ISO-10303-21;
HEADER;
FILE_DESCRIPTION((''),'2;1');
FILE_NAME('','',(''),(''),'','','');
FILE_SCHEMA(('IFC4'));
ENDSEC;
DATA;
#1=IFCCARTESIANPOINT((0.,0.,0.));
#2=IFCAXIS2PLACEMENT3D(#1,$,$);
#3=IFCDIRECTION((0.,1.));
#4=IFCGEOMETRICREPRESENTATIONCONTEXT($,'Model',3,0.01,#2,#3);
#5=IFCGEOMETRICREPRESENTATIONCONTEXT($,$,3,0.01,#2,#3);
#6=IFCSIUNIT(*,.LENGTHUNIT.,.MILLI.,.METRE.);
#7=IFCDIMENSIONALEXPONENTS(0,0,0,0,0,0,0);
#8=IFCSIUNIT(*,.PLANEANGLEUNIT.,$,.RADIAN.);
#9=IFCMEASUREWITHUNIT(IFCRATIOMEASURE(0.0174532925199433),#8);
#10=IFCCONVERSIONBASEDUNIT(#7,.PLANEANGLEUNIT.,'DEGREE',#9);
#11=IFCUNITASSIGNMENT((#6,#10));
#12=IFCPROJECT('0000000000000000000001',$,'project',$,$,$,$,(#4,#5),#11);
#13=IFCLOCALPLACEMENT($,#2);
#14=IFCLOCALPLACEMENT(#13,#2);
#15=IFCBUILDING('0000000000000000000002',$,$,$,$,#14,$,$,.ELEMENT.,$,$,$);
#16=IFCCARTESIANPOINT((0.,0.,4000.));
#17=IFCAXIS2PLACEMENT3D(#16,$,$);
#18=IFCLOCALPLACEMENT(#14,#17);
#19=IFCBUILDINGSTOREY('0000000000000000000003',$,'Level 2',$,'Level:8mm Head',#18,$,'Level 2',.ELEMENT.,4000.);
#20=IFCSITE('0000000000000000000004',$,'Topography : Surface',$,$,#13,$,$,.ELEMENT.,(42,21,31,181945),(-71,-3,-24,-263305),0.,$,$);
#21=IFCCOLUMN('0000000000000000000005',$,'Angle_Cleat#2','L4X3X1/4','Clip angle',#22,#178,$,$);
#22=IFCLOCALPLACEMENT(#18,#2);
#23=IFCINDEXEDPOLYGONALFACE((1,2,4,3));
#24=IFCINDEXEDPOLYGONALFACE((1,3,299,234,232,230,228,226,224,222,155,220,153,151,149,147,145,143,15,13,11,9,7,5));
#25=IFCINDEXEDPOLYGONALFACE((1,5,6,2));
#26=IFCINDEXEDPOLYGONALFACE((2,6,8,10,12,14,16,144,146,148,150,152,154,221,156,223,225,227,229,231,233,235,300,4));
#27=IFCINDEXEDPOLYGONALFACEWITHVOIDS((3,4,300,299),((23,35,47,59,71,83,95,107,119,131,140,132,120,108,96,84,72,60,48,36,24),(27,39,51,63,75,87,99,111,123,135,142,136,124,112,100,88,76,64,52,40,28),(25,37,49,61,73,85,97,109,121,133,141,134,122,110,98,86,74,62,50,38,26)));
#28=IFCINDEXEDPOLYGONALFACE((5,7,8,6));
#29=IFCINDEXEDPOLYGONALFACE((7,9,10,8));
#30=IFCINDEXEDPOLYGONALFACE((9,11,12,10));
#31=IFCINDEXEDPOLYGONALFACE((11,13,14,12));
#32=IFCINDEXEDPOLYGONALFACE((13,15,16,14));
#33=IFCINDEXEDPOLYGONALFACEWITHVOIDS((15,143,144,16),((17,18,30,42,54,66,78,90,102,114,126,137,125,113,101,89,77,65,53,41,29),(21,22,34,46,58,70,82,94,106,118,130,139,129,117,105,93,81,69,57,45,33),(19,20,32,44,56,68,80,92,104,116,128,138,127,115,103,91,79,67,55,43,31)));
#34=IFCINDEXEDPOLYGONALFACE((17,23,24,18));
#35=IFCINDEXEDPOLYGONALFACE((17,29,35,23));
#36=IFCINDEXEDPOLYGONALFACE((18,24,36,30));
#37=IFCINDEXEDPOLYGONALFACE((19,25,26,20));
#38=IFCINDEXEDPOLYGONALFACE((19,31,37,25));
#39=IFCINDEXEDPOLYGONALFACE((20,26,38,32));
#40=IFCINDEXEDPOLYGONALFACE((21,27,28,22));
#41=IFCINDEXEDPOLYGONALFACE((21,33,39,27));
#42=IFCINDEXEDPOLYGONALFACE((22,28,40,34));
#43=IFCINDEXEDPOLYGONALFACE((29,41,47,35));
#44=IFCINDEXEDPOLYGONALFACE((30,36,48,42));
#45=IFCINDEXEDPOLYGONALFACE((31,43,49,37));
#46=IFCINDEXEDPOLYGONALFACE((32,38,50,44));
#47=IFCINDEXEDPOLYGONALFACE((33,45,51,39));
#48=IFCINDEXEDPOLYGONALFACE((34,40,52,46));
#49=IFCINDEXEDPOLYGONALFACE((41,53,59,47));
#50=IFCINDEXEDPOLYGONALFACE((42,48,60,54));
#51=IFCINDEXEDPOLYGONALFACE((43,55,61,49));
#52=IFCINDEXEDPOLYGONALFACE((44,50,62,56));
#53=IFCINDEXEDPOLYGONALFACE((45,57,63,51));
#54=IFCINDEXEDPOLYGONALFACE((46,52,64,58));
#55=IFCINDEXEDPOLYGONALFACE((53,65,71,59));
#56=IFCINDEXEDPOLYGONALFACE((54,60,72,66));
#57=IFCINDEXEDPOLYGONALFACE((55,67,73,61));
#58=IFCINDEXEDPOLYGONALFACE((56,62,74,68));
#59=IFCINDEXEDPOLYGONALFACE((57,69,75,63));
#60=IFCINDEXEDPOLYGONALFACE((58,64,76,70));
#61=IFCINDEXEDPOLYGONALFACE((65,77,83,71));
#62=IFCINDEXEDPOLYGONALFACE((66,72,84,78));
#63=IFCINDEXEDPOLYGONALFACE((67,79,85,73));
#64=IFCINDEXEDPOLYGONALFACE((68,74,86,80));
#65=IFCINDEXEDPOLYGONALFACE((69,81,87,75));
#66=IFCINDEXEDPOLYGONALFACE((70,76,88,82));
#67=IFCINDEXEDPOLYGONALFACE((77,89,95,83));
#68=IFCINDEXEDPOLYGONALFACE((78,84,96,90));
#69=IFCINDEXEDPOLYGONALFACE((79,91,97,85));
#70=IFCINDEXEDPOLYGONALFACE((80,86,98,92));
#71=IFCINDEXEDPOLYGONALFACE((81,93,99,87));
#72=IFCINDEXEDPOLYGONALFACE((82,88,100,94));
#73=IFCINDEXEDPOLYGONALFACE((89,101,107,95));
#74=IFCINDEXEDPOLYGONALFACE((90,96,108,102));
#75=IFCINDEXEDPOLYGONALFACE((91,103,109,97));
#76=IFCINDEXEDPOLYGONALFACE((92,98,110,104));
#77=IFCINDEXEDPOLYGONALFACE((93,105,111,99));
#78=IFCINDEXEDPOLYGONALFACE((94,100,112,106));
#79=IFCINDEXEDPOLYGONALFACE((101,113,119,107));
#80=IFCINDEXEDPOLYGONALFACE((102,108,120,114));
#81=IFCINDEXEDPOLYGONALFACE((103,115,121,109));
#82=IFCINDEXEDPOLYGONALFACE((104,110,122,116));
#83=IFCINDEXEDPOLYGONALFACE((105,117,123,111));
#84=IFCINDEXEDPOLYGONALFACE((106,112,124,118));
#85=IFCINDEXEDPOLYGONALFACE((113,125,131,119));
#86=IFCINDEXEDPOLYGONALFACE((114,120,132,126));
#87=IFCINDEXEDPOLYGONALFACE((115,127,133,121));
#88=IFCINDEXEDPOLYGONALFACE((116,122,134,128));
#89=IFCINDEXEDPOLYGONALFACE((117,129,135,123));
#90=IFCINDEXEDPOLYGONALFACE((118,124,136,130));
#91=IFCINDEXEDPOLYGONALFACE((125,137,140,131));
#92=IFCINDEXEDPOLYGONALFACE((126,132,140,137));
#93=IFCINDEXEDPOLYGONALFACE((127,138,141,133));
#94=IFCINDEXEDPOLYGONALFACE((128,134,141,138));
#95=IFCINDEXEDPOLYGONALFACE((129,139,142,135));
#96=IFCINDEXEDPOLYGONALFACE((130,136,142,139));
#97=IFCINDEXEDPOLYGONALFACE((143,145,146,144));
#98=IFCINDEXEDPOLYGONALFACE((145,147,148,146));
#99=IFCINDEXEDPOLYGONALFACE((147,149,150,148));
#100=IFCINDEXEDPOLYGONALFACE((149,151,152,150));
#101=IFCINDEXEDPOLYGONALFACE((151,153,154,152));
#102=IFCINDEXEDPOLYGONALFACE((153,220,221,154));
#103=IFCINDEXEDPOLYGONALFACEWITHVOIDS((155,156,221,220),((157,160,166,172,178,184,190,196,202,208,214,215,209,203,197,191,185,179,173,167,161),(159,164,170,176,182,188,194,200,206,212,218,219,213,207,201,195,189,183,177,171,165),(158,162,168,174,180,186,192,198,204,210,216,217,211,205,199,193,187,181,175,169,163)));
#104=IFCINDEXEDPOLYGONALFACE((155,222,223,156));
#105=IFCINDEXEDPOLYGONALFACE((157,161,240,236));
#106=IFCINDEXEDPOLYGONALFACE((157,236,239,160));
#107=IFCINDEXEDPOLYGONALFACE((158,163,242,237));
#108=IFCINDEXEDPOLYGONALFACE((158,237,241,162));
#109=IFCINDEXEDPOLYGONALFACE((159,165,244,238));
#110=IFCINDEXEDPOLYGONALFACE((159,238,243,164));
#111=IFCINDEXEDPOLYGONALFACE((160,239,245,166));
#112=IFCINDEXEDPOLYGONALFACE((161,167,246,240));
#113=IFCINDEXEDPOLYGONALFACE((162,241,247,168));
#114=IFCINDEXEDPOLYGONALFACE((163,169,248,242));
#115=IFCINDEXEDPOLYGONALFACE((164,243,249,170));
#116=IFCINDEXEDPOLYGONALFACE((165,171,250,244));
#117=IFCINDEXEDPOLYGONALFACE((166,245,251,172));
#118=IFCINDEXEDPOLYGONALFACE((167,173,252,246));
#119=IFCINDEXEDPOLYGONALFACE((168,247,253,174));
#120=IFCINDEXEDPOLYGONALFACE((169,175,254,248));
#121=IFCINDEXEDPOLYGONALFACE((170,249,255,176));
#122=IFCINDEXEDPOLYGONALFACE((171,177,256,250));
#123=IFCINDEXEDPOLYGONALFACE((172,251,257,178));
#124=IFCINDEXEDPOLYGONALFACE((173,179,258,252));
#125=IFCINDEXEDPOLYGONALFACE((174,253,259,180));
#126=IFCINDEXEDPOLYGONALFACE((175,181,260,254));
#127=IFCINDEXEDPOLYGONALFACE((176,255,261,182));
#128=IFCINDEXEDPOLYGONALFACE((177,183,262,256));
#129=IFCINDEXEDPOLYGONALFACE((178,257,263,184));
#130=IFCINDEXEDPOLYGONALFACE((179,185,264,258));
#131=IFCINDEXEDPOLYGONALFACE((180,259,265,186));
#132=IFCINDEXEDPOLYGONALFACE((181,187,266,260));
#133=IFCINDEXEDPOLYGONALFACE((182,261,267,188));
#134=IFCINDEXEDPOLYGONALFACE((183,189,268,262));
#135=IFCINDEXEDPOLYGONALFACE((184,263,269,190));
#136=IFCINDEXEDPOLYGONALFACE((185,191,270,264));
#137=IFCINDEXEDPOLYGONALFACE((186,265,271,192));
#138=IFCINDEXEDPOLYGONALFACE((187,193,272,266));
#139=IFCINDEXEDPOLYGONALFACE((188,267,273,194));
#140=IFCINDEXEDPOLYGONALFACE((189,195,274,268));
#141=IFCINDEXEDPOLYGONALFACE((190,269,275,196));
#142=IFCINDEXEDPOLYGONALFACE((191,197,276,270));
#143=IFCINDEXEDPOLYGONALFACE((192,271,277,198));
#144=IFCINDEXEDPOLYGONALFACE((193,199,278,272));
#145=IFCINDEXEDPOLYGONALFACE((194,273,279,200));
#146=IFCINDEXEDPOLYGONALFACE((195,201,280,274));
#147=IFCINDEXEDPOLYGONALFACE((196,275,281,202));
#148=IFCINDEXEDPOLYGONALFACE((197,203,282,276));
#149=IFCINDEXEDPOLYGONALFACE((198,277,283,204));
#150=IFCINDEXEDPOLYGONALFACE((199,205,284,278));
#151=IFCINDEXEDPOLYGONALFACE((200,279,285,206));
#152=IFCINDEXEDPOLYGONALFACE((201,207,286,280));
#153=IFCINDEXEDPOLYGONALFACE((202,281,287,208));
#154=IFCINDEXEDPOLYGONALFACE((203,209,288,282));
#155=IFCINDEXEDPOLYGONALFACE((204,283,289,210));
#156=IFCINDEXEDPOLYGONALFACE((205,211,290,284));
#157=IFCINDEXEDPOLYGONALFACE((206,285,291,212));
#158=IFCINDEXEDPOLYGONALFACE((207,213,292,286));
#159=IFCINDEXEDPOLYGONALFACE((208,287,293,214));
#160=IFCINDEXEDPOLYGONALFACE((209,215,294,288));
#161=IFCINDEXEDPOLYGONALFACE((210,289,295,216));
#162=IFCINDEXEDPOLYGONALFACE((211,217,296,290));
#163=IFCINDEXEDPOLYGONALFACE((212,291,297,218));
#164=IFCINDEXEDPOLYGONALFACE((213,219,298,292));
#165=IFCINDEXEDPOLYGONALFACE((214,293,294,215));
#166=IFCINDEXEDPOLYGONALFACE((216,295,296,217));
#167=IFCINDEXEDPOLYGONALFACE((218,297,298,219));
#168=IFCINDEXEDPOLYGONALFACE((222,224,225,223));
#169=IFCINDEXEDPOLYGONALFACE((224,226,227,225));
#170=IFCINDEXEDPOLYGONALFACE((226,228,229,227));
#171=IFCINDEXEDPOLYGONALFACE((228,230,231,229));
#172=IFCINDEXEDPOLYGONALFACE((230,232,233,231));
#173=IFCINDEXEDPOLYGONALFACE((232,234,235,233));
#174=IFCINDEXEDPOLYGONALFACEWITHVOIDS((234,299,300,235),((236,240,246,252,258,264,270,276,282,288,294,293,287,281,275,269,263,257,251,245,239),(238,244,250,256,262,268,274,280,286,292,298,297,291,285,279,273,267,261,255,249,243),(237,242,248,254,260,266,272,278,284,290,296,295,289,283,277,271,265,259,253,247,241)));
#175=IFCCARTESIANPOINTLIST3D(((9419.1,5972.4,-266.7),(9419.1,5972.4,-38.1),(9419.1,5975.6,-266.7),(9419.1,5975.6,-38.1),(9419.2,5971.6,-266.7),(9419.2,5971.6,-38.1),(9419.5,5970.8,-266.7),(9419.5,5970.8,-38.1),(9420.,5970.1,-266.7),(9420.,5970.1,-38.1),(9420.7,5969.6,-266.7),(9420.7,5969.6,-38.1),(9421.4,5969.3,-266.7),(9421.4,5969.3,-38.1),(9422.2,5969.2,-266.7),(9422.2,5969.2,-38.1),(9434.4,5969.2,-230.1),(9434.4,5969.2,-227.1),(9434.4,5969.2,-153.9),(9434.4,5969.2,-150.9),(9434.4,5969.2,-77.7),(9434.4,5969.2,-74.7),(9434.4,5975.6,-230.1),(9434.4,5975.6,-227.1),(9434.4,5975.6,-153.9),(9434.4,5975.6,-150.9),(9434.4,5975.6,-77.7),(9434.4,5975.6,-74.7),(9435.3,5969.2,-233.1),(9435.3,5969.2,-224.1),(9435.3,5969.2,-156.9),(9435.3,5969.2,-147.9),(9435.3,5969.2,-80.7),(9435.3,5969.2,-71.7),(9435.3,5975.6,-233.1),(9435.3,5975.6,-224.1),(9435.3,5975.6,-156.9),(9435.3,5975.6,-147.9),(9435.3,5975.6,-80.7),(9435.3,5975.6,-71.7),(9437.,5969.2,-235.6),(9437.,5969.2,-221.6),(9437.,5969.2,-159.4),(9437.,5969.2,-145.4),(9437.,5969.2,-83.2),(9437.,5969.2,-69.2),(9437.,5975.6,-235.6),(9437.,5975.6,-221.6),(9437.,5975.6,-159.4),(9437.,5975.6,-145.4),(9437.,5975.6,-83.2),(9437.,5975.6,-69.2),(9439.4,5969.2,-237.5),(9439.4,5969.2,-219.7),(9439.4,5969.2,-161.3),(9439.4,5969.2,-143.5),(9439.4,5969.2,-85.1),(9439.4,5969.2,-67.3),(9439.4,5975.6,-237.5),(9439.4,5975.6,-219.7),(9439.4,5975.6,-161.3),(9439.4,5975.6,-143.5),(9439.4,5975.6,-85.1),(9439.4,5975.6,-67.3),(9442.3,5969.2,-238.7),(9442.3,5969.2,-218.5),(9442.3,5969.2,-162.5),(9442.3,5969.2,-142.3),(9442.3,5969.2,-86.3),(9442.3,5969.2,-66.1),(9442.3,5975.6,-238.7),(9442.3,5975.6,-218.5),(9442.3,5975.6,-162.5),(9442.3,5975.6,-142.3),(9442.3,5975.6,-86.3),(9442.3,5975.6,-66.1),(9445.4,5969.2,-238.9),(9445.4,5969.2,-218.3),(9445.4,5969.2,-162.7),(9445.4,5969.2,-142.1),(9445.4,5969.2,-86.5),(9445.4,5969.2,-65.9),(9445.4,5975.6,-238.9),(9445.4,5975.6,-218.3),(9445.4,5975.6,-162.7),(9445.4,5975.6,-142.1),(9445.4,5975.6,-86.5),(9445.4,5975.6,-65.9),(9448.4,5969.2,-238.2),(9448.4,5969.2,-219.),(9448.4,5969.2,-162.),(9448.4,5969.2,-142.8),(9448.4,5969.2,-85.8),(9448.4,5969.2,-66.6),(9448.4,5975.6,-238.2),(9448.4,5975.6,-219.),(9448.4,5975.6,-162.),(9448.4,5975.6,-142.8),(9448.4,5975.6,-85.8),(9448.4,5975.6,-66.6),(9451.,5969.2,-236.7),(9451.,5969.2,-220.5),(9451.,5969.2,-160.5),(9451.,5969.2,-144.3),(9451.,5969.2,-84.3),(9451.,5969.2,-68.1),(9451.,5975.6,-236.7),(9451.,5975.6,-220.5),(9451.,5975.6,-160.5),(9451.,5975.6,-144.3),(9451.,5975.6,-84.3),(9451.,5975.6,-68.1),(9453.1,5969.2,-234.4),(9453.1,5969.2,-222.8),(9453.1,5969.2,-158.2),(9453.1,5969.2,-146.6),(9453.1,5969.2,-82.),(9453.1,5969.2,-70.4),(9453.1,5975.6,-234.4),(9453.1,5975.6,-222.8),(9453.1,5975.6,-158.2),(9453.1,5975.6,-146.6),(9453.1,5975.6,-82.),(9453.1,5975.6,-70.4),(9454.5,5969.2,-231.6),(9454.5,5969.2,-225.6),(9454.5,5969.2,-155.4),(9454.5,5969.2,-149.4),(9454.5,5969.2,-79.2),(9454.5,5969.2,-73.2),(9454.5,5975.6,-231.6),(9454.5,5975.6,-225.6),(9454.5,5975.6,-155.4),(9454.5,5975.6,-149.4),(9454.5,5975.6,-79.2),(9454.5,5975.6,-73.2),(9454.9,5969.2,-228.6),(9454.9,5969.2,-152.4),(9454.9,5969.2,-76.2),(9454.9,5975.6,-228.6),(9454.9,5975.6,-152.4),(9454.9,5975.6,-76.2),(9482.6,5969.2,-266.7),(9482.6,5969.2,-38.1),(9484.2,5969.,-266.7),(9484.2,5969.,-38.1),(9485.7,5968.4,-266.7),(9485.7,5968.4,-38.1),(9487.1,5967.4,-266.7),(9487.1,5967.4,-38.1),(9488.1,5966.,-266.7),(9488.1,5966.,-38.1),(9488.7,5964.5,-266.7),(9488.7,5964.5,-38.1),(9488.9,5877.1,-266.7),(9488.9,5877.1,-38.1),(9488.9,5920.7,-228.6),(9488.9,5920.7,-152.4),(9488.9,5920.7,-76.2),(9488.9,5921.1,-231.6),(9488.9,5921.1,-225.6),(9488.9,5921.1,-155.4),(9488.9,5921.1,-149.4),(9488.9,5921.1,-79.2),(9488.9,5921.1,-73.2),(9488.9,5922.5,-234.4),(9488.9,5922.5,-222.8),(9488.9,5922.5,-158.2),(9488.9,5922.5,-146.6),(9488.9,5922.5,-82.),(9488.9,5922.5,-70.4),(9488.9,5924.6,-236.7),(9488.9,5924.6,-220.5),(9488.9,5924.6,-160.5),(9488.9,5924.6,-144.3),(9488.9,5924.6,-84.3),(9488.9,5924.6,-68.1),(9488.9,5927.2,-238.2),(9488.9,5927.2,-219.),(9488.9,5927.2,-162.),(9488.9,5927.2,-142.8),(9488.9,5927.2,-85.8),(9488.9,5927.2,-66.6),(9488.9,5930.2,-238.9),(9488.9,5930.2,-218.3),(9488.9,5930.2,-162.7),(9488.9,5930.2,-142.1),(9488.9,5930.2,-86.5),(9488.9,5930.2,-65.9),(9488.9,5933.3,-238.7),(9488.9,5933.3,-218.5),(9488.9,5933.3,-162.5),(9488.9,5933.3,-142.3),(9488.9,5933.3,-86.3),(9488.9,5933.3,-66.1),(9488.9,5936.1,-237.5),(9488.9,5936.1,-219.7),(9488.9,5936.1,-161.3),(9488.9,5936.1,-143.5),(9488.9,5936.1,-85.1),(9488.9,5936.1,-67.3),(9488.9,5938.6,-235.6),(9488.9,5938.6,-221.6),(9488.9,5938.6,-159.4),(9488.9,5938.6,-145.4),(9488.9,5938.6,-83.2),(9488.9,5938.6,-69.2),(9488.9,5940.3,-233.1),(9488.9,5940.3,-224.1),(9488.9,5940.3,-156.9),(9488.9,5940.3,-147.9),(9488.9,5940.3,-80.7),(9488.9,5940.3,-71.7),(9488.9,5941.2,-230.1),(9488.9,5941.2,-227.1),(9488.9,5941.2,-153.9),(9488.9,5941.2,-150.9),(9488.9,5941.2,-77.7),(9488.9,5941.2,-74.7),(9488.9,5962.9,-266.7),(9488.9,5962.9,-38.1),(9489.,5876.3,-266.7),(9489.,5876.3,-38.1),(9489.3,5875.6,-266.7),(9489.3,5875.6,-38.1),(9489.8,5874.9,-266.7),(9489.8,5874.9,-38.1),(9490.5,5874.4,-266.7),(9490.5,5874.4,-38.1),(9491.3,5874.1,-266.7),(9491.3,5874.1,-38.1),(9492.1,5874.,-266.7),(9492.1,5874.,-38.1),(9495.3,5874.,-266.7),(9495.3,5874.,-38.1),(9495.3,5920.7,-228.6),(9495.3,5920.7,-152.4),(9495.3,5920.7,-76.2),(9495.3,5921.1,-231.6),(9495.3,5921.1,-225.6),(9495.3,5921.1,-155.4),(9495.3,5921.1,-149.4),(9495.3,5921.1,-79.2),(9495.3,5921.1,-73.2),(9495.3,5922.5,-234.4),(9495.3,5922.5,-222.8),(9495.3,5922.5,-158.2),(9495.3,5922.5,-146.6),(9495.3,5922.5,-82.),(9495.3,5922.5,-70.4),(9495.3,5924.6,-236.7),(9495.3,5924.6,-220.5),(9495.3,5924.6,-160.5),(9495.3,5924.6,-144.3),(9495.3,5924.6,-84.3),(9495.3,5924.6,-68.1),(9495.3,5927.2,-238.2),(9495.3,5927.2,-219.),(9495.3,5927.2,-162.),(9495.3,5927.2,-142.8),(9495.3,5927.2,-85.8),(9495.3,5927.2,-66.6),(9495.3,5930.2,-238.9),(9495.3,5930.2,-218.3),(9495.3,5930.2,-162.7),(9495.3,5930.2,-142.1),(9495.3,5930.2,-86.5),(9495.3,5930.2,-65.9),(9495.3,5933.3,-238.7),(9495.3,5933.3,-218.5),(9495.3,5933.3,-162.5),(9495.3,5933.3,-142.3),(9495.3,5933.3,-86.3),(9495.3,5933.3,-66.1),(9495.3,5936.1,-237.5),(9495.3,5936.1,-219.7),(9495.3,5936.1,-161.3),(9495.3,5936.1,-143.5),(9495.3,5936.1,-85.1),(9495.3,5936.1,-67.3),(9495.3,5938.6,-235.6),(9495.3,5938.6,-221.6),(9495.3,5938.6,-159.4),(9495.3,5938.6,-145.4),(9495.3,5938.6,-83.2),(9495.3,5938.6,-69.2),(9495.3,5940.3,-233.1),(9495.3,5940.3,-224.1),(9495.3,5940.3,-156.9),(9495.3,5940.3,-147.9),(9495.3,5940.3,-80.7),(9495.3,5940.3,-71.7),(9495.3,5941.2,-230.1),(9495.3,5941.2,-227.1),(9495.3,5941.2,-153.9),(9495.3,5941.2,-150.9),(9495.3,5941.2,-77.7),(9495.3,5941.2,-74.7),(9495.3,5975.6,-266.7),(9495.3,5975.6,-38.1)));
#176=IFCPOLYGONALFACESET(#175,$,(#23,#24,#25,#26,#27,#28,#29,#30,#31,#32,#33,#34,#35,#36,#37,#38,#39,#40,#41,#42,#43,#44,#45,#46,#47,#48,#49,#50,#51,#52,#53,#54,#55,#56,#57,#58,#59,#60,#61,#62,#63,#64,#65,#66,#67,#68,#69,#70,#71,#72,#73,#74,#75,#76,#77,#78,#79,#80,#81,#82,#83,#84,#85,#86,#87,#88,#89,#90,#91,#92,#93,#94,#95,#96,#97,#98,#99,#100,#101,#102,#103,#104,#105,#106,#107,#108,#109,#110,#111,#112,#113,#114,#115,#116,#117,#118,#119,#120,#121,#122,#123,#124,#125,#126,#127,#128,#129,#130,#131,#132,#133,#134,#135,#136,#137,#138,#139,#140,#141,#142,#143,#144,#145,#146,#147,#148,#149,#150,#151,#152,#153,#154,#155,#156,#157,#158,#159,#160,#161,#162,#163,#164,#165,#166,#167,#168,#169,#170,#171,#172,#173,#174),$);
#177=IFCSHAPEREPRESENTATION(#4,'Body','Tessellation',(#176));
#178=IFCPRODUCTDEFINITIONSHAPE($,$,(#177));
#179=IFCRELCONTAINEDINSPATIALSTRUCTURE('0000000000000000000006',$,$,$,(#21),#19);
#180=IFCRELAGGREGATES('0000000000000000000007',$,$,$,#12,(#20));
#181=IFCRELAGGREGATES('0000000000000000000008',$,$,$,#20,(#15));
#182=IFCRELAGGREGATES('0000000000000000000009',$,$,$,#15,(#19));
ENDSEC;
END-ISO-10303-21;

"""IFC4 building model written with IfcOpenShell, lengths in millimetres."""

from ifc_helpers import new_model, entity, si_unit, converted_unit, direction, frame, frame_2d, origin, origin_2d_with_axis, place, context, project, spatial, circle, l_section, extrude, element, save


model = new_model("IFC4")

# Units and contexts
model_context = context("Model", 3, precision=0.01, world=origin(), true_north=direction((0.0, 1.0)))
context_of_model = context(None, 3, precision=0.01, world=origin(), true_north=direction((0.0, 1.0)))
ifc_project = project(units=[si_unit("LENGTHUNIT", "METRE", prefix="MILLI"), converted_unit("PLANEANGLEUNIT", "DEGREE", entity("IfcRatioMeasure", 0.0174532925199433), si_unit("PLANEANGLEUNIT", "RADIAN"), dimensions=[0, 0, 0, 0, 0, 0, 0])], contexts=[model_context, context_of_model])

# Site, building, storey
site_placement = place(None, origin())
site = spatial("IfcSite", under=ifc_project, at=site_placement, Name="Topography : Surface", CompositionType="ELEMENT", RefLatitude=(42, 21, 31, 181945), RefLongitude=(-71, -3, -24, -263305), RefElevation=0.0)
building_placement = place(site_placement, origin())
building = spatial("IfcBuilding", under=site, at=building_placement, CompositionType="ELEMENT")
storey_placement = place(building_placement, frame((0.0, 0.0, 4000.0)))
storey = spatial("IfcBuildingStorey", under=building, at=storey_placement, Name="Level 2", ObjectType="Level:8mm Head", LongName="Level 2", CompositionType="ELEMENT", Elevation=4000.0)

# Column, openings
column_1_placement = place(storey_placement, frame((9477.0, 5944.4, -38.1), z_axis=(0.0, 0.0, 1.0), x_axis=(-1.0, 0.0, 0.0)))
column_1 = element("IfcColumn", 1, at=column_1_placement, inside=storey, Name="Angle_Cleat#2", Description="L4X3X1/4", ObjectType="Clip angle", context=model_context, shape_type="SweptSolid", body=[
    extrude(l_section(Depth=101.6, Width=76.2, Thickness=6.3, FilletRadius=6.3, EdgeRadius=3.2, at=frame_2d((19.8, 19.7))), origin(), (0.0, 0.0, -1.0), 228.6),
])
opening_1_placement = place(column_1_placement, frame((-11.6, 13.5, -114.3), z_axis=(-1.0, 0.0, 0.0), x_axis=(0.0, 1.0, 0.0)))
element("IfcOpeningElement", 2, at=opening_1_placement, cuts=column_1, ObjectType="Opening", context=model_context, shape_type="SweptSolid", body=[
    extrude(circle(Radius=10.3, at=origin_2d_with_axis()), origin(), (0.0, 0.0, 1.0), 7.3),
])
opening_2_placement = place(column_1_placement, frame((-11.6, 13.5, -114.3), z_axis=(-1.0, 0.0, 0.0), x_axis=(0.0, 1.0, 0.0)))
element("IfcOpeningElement", 3, at=opening_2_placement, cuts=column_1, ObjectType="Opening", context=model_context, shape_type="SweptSolid", body=[
    extrude(circle(Radius=10.3, at=frame_2d((0.0, 76.2), x_axis=(1.0, 0.0))), origin(), (0.0, 0.0, 1.0), 7.3),
])
opening_3_placement = place(column_1_placement, frame((-11.6, 13.5, -114.3), z_axis=(-1.0, 0.0, 0.0), x_axis=(0.0, 1.0, 0.0)))
element("IfcOpeningElement", 4, at=opening_3_placement, cuts=column_1, ObjectType="Opening", context=model_context, shape_type="SweptSolid", body=[
    extrude(circle(Radius=10.3, at=frame_2d((0.0, -76.2), x_axis=(1.0, 0.0))), origin(), (0.0, 0.0, 1.0), 7.3),
])
opening_4_placement = place(column_1_placement, frame((32.4, -31.5, -114.3), z_axis=(0.0, 1.0, 0.0), x_axis=(-1.0, 0.0, 0.0)))
element("IfcOpeningElement", 5, at=opening_4_placement, cuts=column_1, ObjectType="Opening", context=model_context, shape_type="SweptSolid", body=[
    extrude(circle(Radius=10.3, at=origin_2d_with_axis()), origin(), (0.0, 0.0, 1.0), 7.3),
])
opening_5_placement = place(column_1_placement, frame((32.4, -31.5, -114.3), z_axis=(0.0, 1.0, 0.0), x_axis=(-1.0, 0.0, 0.0)))
element("IfcOpeningElement", 6, at=opening_5_placement, cuts=column_1, ObjectType="Opening", context=model_context, shape_type="SweptSolid", body=[
    extrude(circle(Radius=10.3, at=frame_2d((0.0, 76.2), x_axis=(1.0, 0.0))), origin(), (0.0, 0.0, 1.0), 7.3),
])
opening_6_placement = place(column_1_placement, frame((32.4, -31.5, -114.3), z_axis=(0.0, 1.0, 0.0), x_axis=(-1.0, 0.0, 0.0)))
element("IfcOpeningElement", 7, at=opening_6_placement, cuts=column_1, ObjectType="Opening", context=model_context, shape_type="SweptSolid", body=[
    extrude(circle(Radius=10.3, at=frame_2d((0.0, -76.2), x_axis=(1.0, 0.0))), origin(), (0.0, 0.0, 1.0), 7.3),
])

save(model, "model.ifc")
